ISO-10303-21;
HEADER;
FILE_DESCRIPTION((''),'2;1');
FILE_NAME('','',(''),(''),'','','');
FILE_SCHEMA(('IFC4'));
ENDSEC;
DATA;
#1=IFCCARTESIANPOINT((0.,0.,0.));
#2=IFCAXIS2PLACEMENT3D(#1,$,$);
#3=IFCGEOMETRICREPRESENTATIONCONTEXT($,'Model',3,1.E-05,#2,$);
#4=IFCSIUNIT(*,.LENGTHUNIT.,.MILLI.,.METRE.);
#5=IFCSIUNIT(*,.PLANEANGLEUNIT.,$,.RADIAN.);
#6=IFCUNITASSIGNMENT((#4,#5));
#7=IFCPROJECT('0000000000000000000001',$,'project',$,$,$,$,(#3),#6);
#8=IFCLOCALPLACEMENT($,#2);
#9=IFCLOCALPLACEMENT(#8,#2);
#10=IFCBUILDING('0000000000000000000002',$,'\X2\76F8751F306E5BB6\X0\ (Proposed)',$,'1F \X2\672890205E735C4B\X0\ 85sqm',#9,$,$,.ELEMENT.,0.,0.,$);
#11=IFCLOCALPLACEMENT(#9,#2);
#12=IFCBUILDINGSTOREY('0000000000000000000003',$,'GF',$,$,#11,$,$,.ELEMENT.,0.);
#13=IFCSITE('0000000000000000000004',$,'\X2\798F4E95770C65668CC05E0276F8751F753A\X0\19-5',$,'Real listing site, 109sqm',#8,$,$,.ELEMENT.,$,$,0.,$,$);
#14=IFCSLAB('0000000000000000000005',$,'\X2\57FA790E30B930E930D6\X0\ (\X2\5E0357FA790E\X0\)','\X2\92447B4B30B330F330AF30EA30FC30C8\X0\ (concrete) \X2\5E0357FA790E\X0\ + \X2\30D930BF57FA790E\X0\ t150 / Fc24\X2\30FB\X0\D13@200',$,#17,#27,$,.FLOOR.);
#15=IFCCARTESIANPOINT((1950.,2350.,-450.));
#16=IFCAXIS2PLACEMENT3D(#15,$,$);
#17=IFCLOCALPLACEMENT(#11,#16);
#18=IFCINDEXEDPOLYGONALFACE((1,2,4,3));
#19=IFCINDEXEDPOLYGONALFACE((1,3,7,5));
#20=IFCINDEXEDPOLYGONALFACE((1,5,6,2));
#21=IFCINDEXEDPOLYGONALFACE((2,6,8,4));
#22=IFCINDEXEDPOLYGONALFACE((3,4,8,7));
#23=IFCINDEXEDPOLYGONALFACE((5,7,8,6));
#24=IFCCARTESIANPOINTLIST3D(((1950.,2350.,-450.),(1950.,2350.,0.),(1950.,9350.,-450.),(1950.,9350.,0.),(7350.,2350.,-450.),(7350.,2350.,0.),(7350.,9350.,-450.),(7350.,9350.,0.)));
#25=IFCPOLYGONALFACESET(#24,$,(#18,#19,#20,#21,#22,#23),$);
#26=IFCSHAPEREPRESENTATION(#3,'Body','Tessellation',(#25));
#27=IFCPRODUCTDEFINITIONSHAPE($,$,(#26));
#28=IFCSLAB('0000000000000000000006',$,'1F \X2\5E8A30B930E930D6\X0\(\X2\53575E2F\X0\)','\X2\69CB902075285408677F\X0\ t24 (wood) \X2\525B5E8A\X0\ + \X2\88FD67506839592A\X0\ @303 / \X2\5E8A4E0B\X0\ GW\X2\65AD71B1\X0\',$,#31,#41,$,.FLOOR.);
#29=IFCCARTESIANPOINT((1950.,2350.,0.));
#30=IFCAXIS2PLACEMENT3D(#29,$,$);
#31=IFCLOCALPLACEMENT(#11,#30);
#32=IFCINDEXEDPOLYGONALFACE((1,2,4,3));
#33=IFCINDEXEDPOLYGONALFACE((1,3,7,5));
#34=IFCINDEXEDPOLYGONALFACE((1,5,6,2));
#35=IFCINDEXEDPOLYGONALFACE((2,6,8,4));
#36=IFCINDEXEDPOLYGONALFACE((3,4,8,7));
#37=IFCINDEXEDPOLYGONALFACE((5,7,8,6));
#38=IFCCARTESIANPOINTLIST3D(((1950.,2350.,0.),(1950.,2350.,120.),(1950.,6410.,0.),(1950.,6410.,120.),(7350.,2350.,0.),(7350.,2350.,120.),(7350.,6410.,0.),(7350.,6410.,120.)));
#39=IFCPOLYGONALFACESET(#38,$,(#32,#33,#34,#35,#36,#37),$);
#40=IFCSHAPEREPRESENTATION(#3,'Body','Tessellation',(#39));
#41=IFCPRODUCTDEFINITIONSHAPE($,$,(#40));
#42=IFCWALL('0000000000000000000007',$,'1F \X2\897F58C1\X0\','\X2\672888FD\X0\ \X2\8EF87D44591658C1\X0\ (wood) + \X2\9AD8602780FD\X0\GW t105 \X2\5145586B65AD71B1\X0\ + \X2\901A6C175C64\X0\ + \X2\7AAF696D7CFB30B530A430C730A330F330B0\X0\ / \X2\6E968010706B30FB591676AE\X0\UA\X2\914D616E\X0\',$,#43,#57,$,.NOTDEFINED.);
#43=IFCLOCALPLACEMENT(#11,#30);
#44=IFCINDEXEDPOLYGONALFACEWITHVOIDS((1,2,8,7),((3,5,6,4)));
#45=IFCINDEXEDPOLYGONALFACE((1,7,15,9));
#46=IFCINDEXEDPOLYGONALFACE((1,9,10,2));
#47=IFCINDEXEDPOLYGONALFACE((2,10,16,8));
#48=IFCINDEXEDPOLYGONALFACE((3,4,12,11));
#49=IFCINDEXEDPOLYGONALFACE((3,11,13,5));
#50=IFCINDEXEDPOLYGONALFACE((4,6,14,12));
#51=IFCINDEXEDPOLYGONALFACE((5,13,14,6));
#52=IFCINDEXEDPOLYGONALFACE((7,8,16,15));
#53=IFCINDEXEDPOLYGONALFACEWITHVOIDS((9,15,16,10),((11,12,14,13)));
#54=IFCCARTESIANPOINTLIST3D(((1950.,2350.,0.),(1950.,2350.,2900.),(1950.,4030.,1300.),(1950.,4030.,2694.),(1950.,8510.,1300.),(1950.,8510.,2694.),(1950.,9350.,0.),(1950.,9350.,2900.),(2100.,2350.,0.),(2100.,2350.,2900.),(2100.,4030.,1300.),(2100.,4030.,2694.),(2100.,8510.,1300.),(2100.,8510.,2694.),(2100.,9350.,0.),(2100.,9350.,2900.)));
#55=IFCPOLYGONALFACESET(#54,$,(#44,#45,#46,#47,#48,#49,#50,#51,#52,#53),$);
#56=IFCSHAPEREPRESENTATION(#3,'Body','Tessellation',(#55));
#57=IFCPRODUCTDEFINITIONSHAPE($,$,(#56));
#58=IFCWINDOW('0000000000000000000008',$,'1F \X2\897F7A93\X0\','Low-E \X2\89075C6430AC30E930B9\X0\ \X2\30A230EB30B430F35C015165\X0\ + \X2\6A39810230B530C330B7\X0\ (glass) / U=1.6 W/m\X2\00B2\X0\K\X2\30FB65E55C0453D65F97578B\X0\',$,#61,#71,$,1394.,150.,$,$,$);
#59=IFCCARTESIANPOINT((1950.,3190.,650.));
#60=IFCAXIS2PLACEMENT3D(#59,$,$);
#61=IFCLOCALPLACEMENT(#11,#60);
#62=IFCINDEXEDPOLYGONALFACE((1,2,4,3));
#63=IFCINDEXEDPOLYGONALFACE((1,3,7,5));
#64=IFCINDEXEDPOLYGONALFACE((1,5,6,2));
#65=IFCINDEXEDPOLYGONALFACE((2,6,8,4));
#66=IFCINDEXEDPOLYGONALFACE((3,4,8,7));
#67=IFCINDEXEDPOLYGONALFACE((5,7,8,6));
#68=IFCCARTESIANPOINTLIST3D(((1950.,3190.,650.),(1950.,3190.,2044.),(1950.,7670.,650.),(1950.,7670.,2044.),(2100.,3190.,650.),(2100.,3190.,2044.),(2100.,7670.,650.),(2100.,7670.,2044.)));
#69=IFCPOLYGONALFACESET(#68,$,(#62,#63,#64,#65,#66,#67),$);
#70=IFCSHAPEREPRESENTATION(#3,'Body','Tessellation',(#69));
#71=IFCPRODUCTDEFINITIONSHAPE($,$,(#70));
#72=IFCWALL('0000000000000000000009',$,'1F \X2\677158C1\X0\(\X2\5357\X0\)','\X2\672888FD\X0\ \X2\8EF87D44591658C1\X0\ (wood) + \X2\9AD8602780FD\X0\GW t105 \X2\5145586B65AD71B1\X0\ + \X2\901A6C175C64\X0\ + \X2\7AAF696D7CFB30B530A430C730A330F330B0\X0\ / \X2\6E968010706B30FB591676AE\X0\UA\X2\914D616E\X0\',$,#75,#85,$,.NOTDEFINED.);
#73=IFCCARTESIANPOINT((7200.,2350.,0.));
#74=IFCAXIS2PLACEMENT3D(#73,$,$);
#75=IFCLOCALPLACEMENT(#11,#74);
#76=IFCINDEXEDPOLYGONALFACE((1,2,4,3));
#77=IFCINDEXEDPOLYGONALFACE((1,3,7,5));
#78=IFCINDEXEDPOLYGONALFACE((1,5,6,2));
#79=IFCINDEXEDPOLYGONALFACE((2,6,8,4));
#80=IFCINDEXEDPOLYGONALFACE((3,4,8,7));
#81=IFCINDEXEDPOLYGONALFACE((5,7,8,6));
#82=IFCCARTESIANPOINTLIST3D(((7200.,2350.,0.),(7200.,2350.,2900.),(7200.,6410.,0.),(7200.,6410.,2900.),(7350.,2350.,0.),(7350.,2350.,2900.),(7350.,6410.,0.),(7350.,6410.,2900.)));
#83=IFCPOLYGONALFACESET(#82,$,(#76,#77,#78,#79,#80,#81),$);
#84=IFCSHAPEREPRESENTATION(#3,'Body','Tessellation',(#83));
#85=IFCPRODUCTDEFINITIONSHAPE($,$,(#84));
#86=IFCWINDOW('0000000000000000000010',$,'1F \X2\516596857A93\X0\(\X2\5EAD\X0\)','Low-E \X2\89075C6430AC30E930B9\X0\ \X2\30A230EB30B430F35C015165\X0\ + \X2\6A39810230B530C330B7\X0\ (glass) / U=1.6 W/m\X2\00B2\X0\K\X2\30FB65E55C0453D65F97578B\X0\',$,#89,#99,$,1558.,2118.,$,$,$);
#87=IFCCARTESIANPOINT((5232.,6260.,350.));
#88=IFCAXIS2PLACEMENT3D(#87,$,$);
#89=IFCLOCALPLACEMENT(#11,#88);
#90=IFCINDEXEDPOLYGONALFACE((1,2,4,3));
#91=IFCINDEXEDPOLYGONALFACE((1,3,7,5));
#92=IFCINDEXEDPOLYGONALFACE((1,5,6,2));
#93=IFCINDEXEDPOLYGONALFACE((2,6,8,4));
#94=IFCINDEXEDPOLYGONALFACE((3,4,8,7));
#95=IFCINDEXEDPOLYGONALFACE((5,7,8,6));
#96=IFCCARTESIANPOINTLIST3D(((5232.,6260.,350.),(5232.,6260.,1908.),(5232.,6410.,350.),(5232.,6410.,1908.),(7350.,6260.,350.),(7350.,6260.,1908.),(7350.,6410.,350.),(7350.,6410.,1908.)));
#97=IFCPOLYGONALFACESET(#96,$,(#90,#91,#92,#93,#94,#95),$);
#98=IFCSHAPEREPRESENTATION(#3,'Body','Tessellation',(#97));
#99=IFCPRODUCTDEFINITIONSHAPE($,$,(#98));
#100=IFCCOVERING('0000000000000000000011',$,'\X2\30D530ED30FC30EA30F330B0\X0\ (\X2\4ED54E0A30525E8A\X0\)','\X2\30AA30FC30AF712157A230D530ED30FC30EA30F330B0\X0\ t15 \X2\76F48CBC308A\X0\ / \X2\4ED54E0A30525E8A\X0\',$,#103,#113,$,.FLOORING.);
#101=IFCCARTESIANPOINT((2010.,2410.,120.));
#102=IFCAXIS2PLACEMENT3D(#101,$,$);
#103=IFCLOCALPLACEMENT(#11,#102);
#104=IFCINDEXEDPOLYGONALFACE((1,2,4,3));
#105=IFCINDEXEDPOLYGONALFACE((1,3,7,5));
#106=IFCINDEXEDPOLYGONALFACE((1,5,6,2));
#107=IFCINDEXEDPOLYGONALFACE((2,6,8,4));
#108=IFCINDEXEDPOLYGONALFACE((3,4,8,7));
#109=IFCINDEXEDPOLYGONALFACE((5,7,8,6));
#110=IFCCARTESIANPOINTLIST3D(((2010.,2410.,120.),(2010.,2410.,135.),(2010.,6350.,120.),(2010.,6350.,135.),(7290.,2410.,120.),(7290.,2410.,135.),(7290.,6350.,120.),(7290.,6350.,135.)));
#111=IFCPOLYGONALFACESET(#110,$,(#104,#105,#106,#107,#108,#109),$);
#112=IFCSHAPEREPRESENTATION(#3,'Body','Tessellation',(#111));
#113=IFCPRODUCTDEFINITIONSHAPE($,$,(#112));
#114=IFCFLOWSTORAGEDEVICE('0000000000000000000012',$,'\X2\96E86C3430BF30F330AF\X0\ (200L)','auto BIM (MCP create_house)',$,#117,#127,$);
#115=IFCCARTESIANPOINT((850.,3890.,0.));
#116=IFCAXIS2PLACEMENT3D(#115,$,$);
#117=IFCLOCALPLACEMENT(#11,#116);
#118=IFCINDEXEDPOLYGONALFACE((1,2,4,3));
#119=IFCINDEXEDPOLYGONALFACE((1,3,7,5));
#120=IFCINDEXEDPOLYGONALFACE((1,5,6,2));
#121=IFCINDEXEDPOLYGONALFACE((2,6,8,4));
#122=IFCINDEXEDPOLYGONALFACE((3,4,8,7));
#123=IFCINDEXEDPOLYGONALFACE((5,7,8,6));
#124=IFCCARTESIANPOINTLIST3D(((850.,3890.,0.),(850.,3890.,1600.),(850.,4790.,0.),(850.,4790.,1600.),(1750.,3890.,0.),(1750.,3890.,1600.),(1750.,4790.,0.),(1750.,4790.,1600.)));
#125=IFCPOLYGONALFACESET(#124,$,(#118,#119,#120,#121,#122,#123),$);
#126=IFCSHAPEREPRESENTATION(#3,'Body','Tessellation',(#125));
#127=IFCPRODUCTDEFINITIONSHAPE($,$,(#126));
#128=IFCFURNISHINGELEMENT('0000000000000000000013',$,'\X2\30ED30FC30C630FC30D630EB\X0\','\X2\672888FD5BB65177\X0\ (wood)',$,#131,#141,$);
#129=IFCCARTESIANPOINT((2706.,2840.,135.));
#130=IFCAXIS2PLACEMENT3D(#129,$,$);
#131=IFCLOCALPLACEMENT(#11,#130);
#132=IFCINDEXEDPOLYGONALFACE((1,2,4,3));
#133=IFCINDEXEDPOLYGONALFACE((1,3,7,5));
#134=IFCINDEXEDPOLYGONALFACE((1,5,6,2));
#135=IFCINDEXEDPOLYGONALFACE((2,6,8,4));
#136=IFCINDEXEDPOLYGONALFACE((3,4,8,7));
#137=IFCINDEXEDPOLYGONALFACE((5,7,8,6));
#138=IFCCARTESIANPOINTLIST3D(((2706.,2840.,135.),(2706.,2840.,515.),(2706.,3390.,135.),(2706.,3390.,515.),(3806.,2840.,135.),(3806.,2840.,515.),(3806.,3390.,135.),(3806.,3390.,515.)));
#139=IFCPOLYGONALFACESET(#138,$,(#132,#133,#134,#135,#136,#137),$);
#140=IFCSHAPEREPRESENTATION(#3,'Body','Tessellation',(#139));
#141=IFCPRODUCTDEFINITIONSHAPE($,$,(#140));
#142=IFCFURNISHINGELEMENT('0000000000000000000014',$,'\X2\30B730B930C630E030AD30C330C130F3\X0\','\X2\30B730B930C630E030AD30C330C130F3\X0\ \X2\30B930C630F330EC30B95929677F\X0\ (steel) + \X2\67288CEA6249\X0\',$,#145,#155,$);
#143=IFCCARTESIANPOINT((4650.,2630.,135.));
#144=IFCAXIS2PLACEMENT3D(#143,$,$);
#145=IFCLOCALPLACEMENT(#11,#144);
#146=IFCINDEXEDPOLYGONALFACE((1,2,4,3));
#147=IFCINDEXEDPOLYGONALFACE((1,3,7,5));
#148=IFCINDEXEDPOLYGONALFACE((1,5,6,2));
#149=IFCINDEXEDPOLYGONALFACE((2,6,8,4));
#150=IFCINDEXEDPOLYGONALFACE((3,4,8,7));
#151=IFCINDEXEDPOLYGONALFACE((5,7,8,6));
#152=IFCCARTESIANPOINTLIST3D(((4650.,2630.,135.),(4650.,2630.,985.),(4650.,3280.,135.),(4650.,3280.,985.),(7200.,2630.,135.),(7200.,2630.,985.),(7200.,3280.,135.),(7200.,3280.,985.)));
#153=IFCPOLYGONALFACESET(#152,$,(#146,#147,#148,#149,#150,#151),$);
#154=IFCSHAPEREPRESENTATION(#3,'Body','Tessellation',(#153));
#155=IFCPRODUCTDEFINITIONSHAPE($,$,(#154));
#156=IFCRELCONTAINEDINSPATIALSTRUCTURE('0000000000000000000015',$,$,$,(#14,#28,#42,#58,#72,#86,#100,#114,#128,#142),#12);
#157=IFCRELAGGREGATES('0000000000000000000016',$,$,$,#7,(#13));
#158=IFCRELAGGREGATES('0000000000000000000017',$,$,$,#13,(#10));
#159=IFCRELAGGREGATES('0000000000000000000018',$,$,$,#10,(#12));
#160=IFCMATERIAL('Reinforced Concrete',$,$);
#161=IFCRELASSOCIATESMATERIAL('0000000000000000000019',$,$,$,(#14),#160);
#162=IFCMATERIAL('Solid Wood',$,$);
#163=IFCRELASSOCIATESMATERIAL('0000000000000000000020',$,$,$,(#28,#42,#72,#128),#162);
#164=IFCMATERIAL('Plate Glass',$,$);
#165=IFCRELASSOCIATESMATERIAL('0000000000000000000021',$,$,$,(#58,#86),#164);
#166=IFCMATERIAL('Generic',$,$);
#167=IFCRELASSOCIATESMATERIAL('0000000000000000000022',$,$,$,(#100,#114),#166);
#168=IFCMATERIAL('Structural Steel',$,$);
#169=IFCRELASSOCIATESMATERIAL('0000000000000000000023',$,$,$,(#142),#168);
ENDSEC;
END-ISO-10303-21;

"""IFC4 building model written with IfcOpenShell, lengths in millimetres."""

from ifc_helpers import new_model, si_unit, frame, frame_2d, origin, place, context, project, spatial, rectangle, extrude, material, element, fill, save


model = new_model("IFC4")

# Units and contexts
model_context = context("Model", 3, precision=1e-05, world=origin())
ifc_project = project(units=[si_unit("LENGTHUNIT", "METRE", prefix="MILLI"), si_unit("PLANEANGLEUNIT", "RADIAN")], contexts=[model_context])

# Site, building, storey
site_placement = place(None, origin())
site = spatial("IfcSite", under=ifc_project, at=site_placement, Name="福井県敦賀市相生町19-5", ObjectType="Real listing site, 109sqm", CompositionType="ELEMENT", RefElevation=0.0)
building_placement = place(site_placement, origin())
building = spatial("IfcBuilding", under=site, at=building_placement, Name="相生の家 (Proposed)", ObjectType="1F 木造平屋 85sqm", CompositionType="ELEMENT", ElevationOfRefHeight=0.0, ElevationOfTerrain=0.0)
storey_placement = place(building_placement, origin())
storey = spatial("IfcBuildingStorey", under=building, at=storey_placement, Name="GF", CompositionType="ELEMENT", Elevation=0.0)

# Slabs
ifc_material_1 = material(Name="Reinforced Concrete")
slab_1_placement = place(storey_placement, frame((1950.0, 2350.0, -450.0)))
element("IfcSlab", 1, at=slab_1_placement, inside=storey, material=ifc_material_1, Name="基礎スラブ (布基礎)", Description="鉄筋コンクリート (concrete) 布基礎 + ベタ基礎 t150 / Fc24・D13@200", PredefinedType="FLOOR", context=model_context, shape_type="SweptSolid", body=[
    extrude(rectangle(XDim=5400.0, YDim=7000.0, at=frame_2d((2700.0, 3500.0))), frame((1950.0, 2350.0, -450.0)), (0.0, 0.0, 1.0), 450.0),
])
ifc_material_2 = material(Name="Solid Wood")
slab_2_placement = place(storey_placement, frame((1950.0, 2350.0, 0.0)))
element("IfcSlab", 2, at=slab_2_placement, inside=storey, material=ifc_material_2, Name="1F 床スラブ(南帯)", Description="構造用合板 t24 (wood) 剛床 + 製材根太 @303 / 床下 GW断熱", PredefinedType="FLOOR", context=model_context, shape_type="SweptSolid", body=[
    extrude(rectangle(XDim=5400.0, YDim=4060.0, at=frame_2d((2700.0, 2030.0))), frame((1950.0, 2350.0, 0.0)), (0.0, 0.0, 1.0), 120.0),
])

# Shared definitions
ifc_material_3 = material(Name="Plate Glass")
ifc_material_4 = material(Name="Generic")

# Walls, openings, windows
wall_1_placement = place(storey_placement, frame((1950.0, 2350.0, 0.0)))
wall_1 = element("IfcWall", 3, at=wall_1_placement, inside=storey, material=ifc_material_2, Name="1F 西壁", Description="木製 軸組外壁 (wood) + 高性能GW t105 充填断熱 + 通気層 + 窯業系サイディング / 準耐火・外皮UA配慮", PredefinedType="NOTDEFINED", context=model_context, shape_type="SweptSolid", body=[
    extrude(rectangle(XDim=150.0, YDim=7000.0, at=frame_2d((75.0, 3500.0))), frame((1950.0, 2350.0, 0.0)), (0.0, 0.0, 1.0), 2900.0),
])
opening_1_placement = place(storey_placement, frame((1950.0, 3190.0, 650.0)))
opening_1 = element("IfcOpeningElement", 4, at=opening_1_placement, cuts=wall_1, PredefinedType="NOTDEFINED", context=model_context, shape_type="SweptSolid", body=[
    extrude(rectangle(XDim=150.0, YDim=4480.0, at=frame_2d((75.0, 2240.0))), frame((1950.0, 3190.0, 650.0)), (0.0, 0.0, 1.0), 1394.0),
])
window_1_placement = place(storey_placement, frame((1950.0, 3190.0, 650.0)))
window_1 = element("IfcWindow", 5, at=window_1_placement, inside=storey, material=ifc_material_3, Name="1F 西窓", Description="Low-E 複層ガラス アルゴン封入 + 樹脂サッシ (glass) / U=1.6 W/m²K・日射取得型", OverallHeight=1394.0, OverallWidth=150.0, context=model_context, shape_type="SweptSolid", body=[
    extrude(rectangle(XDim=150.0, YDim=4480.0, at=frame_2d((75.0, 2240.0))), frame((1950.0, 3190.0, 650.0)), (0.0, 0.0, 1.0), 1394.0),
])
fill(opening_1, window_1)
wall_2_placement = place(storey_placement, frame((7200.0, 2350.0, 0.0)))
wall_2 = element("IfcWall", 6, at=wall_2_placement, inside=storey, material=ifc_material_2, Name="1F 東壁(南)", Description="木製 軸組外壁 (wood) + 高性能GW t105 充填断熱 + 通気層 + 窯業系サイディング / 準耐火・外皮UA配慮", PredefinedType="NOTDEFINED", context=model_context, shape_type="SweptSolid", body=[
    extrude(rectangle(XDim=150.0, YDim=4060.0, at=frame_2d((75.0, 2030.0))), frame((7200.0, 2350.0, 0.0)), (0.0, 0.0, 1.0), 2900.0),
])
opening_2_placement = place(storey_placement, frame((5232.0, 6260.0, 350.0)))
opening_2 = element("IfcOpeningElement", 7, at=opening_2_placement, cuts=wall_2, PredefinedType="NOTDEFINED", context=model_context, shape_type="SweptSolid", body=[
    extrude(rectangle(XDim=2118.0, YDim=150.0, at=frame_2d((1059.0, 75.0))), frame((5232.0, 6260.0, 350.0)), (0.0, 0.0, 1.0), 1558.0),
])
window_2_placement = place(storey_placement, frame((5232.0, 6260.0, 350.0)))
window_2 = element("IfcWindow", 8, at=window_2_placement, inside=storey, material=ifc_material_3, Name="1F 入隅窓(庭)", Description="Low-E 複層ガラス アルゴン封入 + 樹脂サッシ (glass) / U=1.6 W/m²K・日射取得型", OverallHeight=1558.0, OverallWidth=2118.0, context=model_context, shape_type="SweptSolid", body=[
    extrude(rectangle(XDim=2118.0, YDim=150.0, at=frame_2d((1059.0, 75.0))), frame((5232.0, 6260.0, 350.0)), (0.0, 0.0, 1.0), 1558.0),
])
fill(opening_2, window_2)

# Covering
covering_placement = place(storey_placement, frame((2010.0, 2410.0, 120.0)))
element("IfcCovering", 9, at=covering_placement, inside=storey, material=ifc_material_4, Name="フローリング (仕上げ床)", Description="オーク無垢フローリング t15 直貼り / 仕上げ床", PredefinedType="FLOORING", context=model_context, shape_type="SweptSolid", body=[
    extrude(rectangle(XDim=5280.0, YDim=3940.0, at=frame_2d((2640.0, 1970.0))), frame((2010.0, 2410.0, 120.0)), (0.0, 0.0, 1.0), 15.0),
])

# Flow storage device
flow_storage_device_placement = place(storey_placement, frame((850.0, 3890.0, 0.0)))
element("IfcFlowStorageDevice", 10, at=flow_storage_device_placement, inside=storey, material=ifc_material_4, Name="雨水タンク (200L)", Description="auto BIM (MCP create_house)", context=model_context, shape_type="SweptSolid", body=[
    extrude(rectangle(XDim=900.0, YDim=900.0, at=frame_2d((450.0, 450.0))), frame((850.0, 3890.0, 0.0)), (0.0, 0.0, 1.0), 1600.0),
])

# Furnishing elements
furnishing_1_placement = place(storey_placement, frame((2706.0, 2840.0, 135.0)))
element("IfcFurnishingElement", 11, at=furnishing_1_placement, inside=storey, material=ifc_material_2, Name="ローテーブル", Description="木製家具 (wood)", context=model_context, shape_type="SweptSolid", body=[
    extrude(rectangle(XDim=1100.0, YDim=550.0, at=frame_2d((550.0, 275.0))), frame((2706.0, 2840.0, 135.0)), (0.0, 0.0, 1.0), 380.0),
])
ifc_material_5 = material(Name="Structural Steel")
furnishing_2_placement = place(storey_placement, frame((4650.0, 2630.0, 135.0)))
element("IfcFurnishingElement", 12, at=furnishing_2_placement, inside=storey, material=ifc_material_5, Name="システムキッチン", Description="システムキッチン ステンレス天板 (steel) + 木質扉", context=model_context, shape_type="SweptSolid", body=[
    extrude(rectangle(XDim=2550.0, YDim=650.0, at=frame_2d((1275.0, 325.0))), frame((4650.0, 2630.0, 135.0)), (0.0, 0.0, 1.0), 850.0),
])

save(model, "model.ifc")
